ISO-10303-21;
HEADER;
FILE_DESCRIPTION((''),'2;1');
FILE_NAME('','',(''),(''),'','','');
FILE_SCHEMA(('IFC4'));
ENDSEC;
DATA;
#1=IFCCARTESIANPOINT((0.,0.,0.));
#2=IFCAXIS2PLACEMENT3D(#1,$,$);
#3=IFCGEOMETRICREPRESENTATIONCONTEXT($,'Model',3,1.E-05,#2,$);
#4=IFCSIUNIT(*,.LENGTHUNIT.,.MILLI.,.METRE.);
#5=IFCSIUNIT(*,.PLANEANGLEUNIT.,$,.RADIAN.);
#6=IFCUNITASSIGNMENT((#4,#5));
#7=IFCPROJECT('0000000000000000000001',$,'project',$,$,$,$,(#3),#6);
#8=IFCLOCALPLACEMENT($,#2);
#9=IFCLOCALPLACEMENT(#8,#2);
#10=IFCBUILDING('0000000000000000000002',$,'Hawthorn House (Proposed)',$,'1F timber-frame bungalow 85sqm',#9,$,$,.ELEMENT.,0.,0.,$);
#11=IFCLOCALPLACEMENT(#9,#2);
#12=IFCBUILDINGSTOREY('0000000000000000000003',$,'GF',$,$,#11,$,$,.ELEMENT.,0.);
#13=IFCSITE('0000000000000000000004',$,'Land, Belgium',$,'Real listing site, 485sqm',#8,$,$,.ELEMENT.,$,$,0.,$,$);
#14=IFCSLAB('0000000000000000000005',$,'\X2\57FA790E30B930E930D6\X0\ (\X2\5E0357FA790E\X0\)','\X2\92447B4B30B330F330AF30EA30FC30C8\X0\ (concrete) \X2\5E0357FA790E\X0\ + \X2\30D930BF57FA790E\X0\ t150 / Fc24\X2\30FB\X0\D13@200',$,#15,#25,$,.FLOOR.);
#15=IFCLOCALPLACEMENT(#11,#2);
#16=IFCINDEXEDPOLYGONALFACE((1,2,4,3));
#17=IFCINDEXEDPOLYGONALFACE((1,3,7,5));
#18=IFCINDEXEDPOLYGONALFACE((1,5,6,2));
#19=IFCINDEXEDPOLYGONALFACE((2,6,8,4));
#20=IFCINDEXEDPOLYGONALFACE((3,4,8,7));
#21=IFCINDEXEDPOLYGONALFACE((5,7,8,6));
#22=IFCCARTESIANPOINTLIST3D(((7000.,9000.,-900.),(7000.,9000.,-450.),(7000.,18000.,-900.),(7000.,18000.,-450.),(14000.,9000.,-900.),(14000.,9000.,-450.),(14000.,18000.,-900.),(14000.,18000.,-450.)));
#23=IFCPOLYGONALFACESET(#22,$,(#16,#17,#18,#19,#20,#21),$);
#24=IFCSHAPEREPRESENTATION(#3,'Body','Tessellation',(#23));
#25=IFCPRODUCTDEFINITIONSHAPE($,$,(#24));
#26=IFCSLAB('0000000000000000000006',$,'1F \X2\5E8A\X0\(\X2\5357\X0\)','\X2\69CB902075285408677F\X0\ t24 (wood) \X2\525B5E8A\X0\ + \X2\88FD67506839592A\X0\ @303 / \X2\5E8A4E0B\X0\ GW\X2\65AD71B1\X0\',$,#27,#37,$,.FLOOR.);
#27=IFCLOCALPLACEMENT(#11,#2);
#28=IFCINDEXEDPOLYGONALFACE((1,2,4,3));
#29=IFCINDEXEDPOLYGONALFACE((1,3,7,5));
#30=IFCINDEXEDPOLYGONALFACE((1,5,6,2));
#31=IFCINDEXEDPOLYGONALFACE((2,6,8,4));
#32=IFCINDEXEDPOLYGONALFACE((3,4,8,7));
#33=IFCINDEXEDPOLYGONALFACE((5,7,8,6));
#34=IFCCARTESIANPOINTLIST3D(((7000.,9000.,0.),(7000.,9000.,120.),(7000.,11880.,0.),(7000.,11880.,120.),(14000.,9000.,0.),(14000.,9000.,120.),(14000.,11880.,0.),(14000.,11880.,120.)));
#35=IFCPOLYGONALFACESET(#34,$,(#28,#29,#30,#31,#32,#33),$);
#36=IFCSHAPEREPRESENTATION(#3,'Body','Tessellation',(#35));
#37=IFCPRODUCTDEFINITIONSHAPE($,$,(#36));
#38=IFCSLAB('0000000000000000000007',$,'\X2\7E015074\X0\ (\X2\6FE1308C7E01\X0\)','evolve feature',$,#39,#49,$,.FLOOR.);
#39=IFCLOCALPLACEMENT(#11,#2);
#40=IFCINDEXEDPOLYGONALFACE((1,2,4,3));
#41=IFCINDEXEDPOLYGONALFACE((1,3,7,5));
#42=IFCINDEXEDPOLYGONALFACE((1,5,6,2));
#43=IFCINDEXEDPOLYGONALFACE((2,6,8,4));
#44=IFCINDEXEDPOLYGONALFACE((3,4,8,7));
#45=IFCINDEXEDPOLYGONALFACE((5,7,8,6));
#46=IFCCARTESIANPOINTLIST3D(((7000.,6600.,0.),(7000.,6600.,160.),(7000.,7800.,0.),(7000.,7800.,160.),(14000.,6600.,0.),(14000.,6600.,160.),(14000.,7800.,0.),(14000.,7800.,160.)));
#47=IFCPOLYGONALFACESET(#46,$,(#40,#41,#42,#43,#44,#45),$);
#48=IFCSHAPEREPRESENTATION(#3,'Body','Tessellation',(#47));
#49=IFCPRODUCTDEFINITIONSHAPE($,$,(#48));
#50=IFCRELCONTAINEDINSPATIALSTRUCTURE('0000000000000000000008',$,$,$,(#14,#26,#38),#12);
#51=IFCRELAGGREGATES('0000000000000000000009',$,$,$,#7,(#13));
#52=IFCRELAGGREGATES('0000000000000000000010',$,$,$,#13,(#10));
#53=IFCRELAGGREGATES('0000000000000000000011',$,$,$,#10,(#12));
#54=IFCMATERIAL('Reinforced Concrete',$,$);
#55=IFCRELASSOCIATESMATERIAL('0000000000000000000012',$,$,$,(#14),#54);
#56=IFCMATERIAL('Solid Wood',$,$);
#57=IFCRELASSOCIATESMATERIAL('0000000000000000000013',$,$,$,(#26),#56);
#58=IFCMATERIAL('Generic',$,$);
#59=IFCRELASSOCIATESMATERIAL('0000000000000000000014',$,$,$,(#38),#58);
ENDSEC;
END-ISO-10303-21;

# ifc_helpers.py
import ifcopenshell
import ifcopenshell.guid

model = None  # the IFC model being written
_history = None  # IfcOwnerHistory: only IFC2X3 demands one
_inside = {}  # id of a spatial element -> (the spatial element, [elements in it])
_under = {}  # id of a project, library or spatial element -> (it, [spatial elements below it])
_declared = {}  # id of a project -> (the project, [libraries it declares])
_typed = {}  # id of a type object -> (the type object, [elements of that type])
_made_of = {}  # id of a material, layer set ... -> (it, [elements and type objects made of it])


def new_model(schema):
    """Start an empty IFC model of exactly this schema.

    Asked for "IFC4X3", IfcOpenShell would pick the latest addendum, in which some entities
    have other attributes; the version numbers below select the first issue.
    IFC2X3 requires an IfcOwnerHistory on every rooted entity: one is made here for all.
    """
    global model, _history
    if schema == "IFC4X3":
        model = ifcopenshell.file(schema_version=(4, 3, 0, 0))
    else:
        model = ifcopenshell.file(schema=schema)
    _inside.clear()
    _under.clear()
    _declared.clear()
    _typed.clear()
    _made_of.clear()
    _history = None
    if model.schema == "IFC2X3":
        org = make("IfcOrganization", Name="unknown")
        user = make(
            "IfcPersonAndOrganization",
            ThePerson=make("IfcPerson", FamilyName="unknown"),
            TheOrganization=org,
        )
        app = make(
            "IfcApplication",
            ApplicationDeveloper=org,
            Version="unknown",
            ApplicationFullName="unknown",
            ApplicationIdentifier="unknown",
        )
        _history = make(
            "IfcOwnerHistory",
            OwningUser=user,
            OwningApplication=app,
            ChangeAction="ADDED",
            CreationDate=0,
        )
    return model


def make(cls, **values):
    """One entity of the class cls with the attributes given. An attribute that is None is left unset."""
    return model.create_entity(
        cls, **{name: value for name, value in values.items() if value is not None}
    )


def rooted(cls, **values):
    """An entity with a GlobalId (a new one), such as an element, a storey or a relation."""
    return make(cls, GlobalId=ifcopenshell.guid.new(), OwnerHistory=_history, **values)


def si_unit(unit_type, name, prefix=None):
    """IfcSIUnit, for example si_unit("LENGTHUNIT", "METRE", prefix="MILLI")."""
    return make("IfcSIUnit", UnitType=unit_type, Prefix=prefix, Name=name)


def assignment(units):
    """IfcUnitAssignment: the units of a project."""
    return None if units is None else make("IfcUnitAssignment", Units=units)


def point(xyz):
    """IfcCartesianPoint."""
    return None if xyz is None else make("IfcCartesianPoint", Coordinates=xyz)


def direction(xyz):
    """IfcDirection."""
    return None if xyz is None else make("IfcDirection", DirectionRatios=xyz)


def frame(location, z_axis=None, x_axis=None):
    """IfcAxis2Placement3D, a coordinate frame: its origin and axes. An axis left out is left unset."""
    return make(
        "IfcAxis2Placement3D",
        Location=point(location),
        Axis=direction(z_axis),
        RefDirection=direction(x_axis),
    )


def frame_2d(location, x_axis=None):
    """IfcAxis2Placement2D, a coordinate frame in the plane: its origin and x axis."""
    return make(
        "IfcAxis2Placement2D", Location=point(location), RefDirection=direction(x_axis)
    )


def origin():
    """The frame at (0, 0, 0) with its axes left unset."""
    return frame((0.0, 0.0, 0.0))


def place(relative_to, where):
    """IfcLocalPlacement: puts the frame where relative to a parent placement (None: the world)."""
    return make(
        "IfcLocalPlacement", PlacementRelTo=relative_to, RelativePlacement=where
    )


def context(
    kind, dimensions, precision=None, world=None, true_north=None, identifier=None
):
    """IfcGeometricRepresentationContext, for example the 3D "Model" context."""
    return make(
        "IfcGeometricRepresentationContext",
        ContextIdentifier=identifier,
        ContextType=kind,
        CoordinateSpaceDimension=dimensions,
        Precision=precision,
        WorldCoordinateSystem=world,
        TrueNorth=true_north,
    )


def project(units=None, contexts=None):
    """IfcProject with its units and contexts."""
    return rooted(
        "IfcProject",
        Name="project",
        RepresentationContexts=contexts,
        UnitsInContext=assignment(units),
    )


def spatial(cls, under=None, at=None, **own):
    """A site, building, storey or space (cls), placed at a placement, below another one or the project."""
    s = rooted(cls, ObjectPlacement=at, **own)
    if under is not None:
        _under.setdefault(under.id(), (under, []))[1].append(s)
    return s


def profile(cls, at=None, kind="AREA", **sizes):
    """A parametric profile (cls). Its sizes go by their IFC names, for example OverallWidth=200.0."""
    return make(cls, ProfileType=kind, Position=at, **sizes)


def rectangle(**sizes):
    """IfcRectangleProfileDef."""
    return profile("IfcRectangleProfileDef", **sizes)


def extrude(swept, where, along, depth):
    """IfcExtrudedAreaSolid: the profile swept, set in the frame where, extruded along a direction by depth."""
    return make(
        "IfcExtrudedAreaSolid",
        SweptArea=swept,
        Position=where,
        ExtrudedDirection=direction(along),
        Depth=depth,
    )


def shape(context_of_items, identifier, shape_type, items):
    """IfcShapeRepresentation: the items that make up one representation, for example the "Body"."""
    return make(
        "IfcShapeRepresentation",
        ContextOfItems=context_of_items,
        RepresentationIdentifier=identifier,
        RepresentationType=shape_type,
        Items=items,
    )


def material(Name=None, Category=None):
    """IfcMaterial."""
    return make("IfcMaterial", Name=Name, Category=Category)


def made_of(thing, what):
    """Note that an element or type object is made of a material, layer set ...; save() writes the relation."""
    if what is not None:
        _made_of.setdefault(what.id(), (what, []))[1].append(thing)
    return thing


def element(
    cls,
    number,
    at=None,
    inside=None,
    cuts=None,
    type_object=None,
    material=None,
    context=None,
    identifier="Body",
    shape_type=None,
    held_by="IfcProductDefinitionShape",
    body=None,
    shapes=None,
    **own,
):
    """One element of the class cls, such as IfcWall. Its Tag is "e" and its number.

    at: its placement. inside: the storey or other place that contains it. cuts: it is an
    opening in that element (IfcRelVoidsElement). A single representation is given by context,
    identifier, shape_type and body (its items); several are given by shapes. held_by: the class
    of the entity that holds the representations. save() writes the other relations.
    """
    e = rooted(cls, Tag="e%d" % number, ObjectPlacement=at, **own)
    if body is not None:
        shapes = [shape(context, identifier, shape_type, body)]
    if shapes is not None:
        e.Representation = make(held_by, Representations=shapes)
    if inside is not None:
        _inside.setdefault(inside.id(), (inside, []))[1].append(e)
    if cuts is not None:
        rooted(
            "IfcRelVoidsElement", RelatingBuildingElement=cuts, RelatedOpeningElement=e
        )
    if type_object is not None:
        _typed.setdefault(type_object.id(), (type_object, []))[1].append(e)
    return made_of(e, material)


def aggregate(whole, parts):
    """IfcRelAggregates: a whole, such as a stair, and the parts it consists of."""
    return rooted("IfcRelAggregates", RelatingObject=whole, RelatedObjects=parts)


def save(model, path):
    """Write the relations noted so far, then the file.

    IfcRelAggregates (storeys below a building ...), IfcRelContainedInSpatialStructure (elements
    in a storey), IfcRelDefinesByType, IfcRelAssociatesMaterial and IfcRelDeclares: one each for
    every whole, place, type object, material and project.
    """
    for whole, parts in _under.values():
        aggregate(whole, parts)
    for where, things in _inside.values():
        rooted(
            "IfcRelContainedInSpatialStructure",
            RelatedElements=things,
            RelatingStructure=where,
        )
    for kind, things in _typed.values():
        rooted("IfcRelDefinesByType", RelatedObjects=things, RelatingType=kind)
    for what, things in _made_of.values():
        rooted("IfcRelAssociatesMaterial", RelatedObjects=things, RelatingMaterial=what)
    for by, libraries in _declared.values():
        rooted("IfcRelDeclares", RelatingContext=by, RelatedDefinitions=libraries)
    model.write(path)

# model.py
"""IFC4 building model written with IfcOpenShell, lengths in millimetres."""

from ifc_helpers import new_model, si_unit, frame, frame_2d, origin, place, context, project, spatial, rectangle, extrude, material, element, save


model = new_model("IFC4")

# Units and contexts
model_context = context("Model", 3, precision=1e-05, world=origin())
ifc_project = project(units=[si_unit("LENGTHUNIT", "METRE", prefix="MILLI"), si_unit("PLANEANGLEUNIT", "RADIAN")], contexts=[model_context])

# Site, building, storey
site_placement = place(None, origin())
site = spatial("IfcSite", under=ifc_project, at=site_placement, Name="Land, Belgium", ObjectType="Real listing site, 485sqm", CompositionType="ELEMENT", RefElevation=0.0)
building_placement = place(site_placement, origin())
building = spatial("IfcBuilding", under=site, at=building_placement, Name="Hawthorn House (Proposed)", ObjectType="1F timber-frame bungalow 85sqm", CompositionType="ELEMENT", ElevationOfRefHeight=0.0, ElevationOfTerrain=0.0)
storey_placement = place(building_placement, origin())
storey = spatial("IfcBuildingStorey", under=building, at=storey_placement, Name="GF", CompositionType="ELEMENT", Elevation=0.0)

# Slabs
ifc_material_1 = material(Name="Reinforced Concrete")
slab_1_placement = place(storey_placement, frame((3500.0, 4500.0, -450.0)))
element("IfcSlab", 1, at=slab_1_placement, inside=storey, material=ifc_material_1, Name="基礎スラブ (布基礎)", Description="鉄筋コンクリート (concrete) 布基礎 + ベタ基礎 t150 / Fc24・D13@200", PredefinedType="FLOOR", context=model_context, shape_type="SweptSolid", body=[
    extrude(rectangle(XDim=7000.0, YDim=9000.0, at=frame_2d((3500.0, 4500.0))), frame((3500.0, 4500.0, -450.0)), (0.0, 0.0, 1.0), 450.0),
])
ifc_material_2 = material(Name="Solid Wood")
slab_2_placement = place(storey_placement, frame((3500.0, 4500.0, 0.0)))
element("IfcSlab", 2, at=slab_2_placement, inside=storey, material=ifc_material_2, Name="1F 床(南)", Description="構造用合板 t24 (wood) 剛床 + 製材根太 @303 / 床下 GW断熱", PredefinedType="FLOOR", context=model_context, shape_type="SweptSolid", body=[
    extrude(rectangle(XDim=7000.0, YDim=2880.0, at=frame_2d((3500.0, 1440.0))), frame((3500.0, 4500.0, 0.0)), (0.0, 0.0, 1.0), 120.0),
])
ifc_material_3 = material(Name="Generic")
slab_3_placement = place(storey_placement, frame((3500.0, 3300.0, 0.0)))
element("IfcSlab", 3, at=slab_3_placement, inside=storey, material=ifc_material_3, Name="縁側 (濡れ縁)", Description="evolve feature", PredefinedType="FLOOR", context=model_context, shape_type="SweptSolid", body=[
    extrude(rectangle(XDim=7000.0, YDim=1200.0, at=frame_2d((3500.0, 600.0))), frame((3500.0, 3300.0, 0.0)), (0.0, 0.0, 1.0), 160.0),
])

save(model, "model.ifc")
